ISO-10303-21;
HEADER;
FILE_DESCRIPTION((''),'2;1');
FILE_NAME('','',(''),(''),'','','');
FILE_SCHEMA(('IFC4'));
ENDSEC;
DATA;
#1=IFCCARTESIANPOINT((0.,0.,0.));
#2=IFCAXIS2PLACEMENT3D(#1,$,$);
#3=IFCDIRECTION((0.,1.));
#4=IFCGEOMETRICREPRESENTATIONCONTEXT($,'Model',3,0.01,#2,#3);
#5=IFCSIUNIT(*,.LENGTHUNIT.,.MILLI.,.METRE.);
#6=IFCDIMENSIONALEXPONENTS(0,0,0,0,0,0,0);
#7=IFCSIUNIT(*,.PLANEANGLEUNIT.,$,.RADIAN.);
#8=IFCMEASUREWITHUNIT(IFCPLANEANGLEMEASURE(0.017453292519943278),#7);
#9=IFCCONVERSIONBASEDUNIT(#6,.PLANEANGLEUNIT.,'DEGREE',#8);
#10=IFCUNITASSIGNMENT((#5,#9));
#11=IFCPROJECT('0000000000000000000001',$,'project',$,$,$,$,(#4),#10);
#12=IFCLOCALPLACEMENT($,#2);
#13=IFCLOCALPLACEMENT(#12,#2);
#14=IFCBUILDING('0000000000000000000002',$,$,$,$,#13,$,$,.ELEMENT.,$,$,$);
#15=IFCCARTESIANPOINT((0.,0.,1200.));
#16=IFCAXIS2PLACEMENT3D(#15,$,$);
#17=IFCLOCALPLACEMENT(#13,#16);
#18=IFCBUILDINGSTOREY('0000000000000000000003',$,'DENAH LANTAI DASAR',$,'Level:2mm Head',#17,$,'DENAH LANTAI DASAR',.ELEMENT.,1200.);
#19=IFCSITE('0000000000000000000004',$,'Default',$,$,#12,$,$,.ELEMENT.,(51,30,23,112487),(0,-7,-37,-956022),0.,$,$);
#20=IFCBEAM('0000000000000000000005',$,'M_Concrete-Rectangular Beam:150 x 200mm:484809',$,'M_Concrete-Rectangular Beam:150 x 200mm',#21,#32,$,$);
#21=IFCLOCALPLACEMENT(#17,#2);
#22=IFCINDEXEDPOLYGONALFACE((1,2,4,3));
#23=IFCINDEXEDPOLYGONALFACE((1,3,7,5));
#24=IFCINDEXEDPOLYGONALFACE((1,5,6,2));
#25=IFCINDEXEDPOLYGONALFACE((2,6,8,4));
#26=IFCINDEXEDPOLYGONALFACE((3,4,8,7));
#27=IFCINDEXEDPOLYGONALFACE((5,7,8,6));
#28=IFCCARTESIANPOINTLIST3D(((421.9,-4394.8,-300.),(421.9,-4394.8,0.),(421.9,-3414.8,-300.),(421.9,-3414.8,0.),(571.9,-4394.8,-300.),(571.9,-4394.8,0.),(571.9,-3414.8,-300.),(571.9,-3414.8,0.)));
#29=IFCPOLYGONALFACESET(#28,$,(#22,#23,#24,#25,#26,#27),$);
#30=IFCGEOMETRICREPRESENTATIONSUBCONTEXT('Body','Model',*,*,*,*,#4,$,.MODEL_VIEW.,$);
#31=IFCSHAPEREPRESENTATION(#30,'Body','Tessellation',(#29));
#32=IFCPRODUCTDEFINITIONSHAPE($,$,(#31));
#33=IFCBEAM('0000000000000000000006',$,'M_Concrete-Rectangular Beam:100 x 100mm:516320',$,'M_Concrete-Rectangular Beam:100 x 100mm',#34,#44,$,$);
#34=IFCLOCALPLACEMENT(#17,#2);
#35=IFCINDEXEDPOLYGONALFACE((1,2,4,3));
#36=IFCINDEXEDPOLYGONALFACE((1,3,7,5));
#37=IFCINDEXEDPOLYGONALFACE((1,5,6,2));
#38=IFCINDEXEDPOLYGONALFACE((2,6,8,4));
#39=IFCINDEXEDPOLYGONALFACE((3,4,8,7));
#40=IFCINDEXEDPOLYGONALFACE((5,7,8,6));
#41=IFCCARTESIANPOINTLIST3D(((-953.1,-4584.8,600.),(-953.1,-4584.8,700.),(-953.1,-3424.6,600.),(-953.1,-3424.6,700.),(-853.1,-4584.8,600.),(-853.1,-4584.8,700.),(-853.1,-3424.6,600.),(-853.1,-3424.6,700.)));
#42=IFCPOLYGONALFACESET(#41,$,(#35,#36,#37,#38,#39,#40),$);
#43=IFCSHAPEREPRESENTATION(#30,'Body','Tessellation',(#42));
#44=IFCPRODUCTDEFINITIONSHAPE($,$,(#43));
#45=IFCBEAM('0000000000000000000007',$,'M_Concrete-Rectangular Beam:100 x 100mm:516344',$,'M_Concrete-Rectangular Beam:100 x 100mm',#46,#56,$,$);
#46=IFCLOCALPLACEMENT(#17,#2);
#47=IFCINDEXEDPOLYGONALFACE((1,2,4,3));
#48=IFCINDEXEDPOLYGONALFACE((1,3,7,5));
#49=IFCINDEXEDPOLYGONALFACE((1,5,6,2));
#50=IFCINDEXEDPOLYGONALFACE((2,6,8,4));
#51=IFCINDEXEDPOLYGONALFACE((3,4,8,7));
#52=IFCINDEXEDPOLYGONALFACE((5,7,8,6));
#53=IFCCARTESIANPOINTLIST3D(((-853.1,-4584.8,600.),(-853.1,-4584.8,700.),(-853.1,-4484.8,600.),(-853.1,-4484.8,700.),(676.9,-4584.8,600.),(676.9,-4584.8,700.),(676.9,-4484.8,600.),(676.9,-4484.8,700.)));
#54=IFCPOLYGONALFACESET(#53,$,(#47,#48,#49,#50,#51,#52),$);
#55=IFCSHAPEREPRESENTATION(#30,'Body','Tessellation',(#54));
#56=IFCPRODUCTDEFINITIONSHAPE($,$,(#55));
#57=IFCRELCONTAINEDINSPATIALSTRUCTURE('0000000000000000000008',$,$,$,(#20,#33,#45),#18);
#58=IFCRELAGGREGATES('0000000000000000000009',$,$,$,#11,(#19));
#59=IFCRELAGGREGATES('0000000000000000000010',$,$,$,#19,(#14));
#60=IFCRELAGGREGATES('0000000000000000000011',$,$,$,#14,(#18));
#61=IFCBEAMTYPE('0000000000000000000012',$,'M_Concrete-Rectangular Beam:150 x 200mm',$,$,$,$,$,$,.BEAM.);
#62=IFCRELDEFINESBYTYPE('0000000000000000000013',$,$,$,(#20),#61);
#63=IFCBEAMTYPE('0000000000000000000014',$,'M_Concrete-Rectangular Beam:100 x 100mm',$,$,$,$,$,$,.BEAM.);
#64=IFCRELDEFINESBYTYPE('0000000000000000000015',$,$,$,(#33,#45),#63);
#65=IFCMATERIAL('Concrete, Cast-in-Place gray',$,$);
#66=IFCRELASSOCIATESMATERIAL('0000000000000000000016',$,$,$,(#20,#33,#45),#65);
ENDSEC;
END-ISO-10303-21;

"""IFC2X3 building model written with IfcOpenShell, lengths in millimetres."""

from ifc_helpers import new_model, entity, si_unit, converted_unit, direction, frame, frame_2d, origin, place, context, subcontext, project, spatial, rectangle, extrude, material, type_object, element, save


model = new_model("IFC2X3")

# Units and contexts
model_context = context("Model", 3, precision=0.01, world=origin(), true_north=direction((0.0, 1.0)))
body_context = subcontext(model_context, "Body", "Model", "MODEL_VIEW")
ifc_project = project(units=[si_unit("LENGTHUNIT", "METRE", prefix="MILLI"), converted_unit("PLANEANGLEUNIT", "DEGREE", entity("IfcPlaneAngleMeasure", 0.017453292519943278), si_unit("PLANEANGLEUNIT", "RADIAN"), dimensions=[0, 0, 0, 0, 0, 0, 0])], contexts=[model_context])

# Site, building, storey
site_placement = place(None, origin())
site = spatial("IfcSite", under=ifc_project, at=site_placement, Name="Default", CompositionType="ELEMENT", RefLatitude=(51, 30, 23, 112487), RefLongitude=(0, -7, -37, -956022), RefElevation=0.0)
building_placement = place(site_placement, origin())
building = spatial("IfcBuilding", under=site, at=building_placement, CompositionType="ELEMENT")
storey_placement = place(building_placement, frame((0.0, 0.0, 1200.0)))
storey = spatial("IfcBuildingStorey", under=building, at=storey_placement, Name="DENAH LANTAI DASAR", ObjectType="Level:2mm Head", LongName="DENAH LANTAI DASAR", CompositionType="ELEMENT", Elevation=1200.0)

# Beams
ifc_material_1 = material(Name="Concrete, Cast-in-Place gray")
beam_type_1 = type_object("IfcBeamType", Name="M_Concrete-Rectangular Beam:150 x 200mm", PredefinedType="BEAM")
beam_1_placement = place(storey_placement, frame((496.9, -3414.8, 0.0), z_axis=(0.0, 0.0, 1.0), x_axis=(0.0, -1.0, 0.0)))
element("IfcBeam", 1, at=beam_1_placement, inside=storey, type_object=beam_type_1, material=ifc_material_1, Name="M_Concrete-Rectangular Beam:150 x 200mm:484809", ObjectType="M_Concrete-Rectangular Beam:150 x 200mm", context=body_context, shape_type="SweptSolid", body=[
    extrude(rectangle(XDim=300.0, YDim=150.0, at=frame_2d((0.0, 0.0), x_axis=(1.0, 0.0))), frame((0.0, 0.0, -150.0), z_axis=(1.0, 0.0, 0.0), x_axis=(0.0, 0.0, -1.0)), (0.0, 0.0, 1.0), 980.0),
])
beam_type_2 = type_object("IfcBeamType", Name="M_Concrete-Rectangular Beam:100 x 100mm", PredefinedType="BEAM")
beam_2_placement = place(storey_placement, frame((-903.1, -3424.6, 700.0), z_axis=(0.0, 0.0, 1.0), x_axis=(0.0, -1.0, 0.0)))
element("IfcBeam", 2, at=beam_2_placement, inside=storey, type_object=beam_type_2, material=ifc_material_1, Name="M_Concrete-Rectangular Beam:100 x 100mm:516320", ObjectType="M_Concrete-Rectangular Beam:100 x 100mm", context=body_context, shape_type="SweptSolid", body=[
    extrude(rectangle(XDim=100.0, YDim=100.0, at=frame_2d((0.0, 0.0), x_axis=(1.0, 0.0))), frame((0.0, 0.0, -50.0), z_axis=(1.0, 0.0, 0.0), x_axis=(0.0, 0.0, -1.0)), (0.0, 0.0, 1.0), 1160.2),
])
beam_3_placement = place(storey_placement, frame((-903.1, -4534.8, 700.0)))
element("IfcBeam", 3, at=beam_3_placement, inside=storey, type_object=beam_type_2, material=ifc_material_1, Name="M_Concrete-Rectangular Beam:100 x 100mm:516344", ObjectType="M_Concrete-Rectangular Beam:100 x 100mm", context=body_context, shape_type="SweptSolid", body=[
    extrude(rectangle(XDim=100.0, YDim=100.0, at=frame_2d((0.0, 0.0), x_axis=(1.0, 0.0))), frame((50.0, 0.0, -50.0), z_axis=(1.0, 0.0, 0.0), x_axis=(0.0, 0.0, -1.0)), (0.0, 0.0, 1.0), 1530.0),
])

save(model, "model.ifc")
